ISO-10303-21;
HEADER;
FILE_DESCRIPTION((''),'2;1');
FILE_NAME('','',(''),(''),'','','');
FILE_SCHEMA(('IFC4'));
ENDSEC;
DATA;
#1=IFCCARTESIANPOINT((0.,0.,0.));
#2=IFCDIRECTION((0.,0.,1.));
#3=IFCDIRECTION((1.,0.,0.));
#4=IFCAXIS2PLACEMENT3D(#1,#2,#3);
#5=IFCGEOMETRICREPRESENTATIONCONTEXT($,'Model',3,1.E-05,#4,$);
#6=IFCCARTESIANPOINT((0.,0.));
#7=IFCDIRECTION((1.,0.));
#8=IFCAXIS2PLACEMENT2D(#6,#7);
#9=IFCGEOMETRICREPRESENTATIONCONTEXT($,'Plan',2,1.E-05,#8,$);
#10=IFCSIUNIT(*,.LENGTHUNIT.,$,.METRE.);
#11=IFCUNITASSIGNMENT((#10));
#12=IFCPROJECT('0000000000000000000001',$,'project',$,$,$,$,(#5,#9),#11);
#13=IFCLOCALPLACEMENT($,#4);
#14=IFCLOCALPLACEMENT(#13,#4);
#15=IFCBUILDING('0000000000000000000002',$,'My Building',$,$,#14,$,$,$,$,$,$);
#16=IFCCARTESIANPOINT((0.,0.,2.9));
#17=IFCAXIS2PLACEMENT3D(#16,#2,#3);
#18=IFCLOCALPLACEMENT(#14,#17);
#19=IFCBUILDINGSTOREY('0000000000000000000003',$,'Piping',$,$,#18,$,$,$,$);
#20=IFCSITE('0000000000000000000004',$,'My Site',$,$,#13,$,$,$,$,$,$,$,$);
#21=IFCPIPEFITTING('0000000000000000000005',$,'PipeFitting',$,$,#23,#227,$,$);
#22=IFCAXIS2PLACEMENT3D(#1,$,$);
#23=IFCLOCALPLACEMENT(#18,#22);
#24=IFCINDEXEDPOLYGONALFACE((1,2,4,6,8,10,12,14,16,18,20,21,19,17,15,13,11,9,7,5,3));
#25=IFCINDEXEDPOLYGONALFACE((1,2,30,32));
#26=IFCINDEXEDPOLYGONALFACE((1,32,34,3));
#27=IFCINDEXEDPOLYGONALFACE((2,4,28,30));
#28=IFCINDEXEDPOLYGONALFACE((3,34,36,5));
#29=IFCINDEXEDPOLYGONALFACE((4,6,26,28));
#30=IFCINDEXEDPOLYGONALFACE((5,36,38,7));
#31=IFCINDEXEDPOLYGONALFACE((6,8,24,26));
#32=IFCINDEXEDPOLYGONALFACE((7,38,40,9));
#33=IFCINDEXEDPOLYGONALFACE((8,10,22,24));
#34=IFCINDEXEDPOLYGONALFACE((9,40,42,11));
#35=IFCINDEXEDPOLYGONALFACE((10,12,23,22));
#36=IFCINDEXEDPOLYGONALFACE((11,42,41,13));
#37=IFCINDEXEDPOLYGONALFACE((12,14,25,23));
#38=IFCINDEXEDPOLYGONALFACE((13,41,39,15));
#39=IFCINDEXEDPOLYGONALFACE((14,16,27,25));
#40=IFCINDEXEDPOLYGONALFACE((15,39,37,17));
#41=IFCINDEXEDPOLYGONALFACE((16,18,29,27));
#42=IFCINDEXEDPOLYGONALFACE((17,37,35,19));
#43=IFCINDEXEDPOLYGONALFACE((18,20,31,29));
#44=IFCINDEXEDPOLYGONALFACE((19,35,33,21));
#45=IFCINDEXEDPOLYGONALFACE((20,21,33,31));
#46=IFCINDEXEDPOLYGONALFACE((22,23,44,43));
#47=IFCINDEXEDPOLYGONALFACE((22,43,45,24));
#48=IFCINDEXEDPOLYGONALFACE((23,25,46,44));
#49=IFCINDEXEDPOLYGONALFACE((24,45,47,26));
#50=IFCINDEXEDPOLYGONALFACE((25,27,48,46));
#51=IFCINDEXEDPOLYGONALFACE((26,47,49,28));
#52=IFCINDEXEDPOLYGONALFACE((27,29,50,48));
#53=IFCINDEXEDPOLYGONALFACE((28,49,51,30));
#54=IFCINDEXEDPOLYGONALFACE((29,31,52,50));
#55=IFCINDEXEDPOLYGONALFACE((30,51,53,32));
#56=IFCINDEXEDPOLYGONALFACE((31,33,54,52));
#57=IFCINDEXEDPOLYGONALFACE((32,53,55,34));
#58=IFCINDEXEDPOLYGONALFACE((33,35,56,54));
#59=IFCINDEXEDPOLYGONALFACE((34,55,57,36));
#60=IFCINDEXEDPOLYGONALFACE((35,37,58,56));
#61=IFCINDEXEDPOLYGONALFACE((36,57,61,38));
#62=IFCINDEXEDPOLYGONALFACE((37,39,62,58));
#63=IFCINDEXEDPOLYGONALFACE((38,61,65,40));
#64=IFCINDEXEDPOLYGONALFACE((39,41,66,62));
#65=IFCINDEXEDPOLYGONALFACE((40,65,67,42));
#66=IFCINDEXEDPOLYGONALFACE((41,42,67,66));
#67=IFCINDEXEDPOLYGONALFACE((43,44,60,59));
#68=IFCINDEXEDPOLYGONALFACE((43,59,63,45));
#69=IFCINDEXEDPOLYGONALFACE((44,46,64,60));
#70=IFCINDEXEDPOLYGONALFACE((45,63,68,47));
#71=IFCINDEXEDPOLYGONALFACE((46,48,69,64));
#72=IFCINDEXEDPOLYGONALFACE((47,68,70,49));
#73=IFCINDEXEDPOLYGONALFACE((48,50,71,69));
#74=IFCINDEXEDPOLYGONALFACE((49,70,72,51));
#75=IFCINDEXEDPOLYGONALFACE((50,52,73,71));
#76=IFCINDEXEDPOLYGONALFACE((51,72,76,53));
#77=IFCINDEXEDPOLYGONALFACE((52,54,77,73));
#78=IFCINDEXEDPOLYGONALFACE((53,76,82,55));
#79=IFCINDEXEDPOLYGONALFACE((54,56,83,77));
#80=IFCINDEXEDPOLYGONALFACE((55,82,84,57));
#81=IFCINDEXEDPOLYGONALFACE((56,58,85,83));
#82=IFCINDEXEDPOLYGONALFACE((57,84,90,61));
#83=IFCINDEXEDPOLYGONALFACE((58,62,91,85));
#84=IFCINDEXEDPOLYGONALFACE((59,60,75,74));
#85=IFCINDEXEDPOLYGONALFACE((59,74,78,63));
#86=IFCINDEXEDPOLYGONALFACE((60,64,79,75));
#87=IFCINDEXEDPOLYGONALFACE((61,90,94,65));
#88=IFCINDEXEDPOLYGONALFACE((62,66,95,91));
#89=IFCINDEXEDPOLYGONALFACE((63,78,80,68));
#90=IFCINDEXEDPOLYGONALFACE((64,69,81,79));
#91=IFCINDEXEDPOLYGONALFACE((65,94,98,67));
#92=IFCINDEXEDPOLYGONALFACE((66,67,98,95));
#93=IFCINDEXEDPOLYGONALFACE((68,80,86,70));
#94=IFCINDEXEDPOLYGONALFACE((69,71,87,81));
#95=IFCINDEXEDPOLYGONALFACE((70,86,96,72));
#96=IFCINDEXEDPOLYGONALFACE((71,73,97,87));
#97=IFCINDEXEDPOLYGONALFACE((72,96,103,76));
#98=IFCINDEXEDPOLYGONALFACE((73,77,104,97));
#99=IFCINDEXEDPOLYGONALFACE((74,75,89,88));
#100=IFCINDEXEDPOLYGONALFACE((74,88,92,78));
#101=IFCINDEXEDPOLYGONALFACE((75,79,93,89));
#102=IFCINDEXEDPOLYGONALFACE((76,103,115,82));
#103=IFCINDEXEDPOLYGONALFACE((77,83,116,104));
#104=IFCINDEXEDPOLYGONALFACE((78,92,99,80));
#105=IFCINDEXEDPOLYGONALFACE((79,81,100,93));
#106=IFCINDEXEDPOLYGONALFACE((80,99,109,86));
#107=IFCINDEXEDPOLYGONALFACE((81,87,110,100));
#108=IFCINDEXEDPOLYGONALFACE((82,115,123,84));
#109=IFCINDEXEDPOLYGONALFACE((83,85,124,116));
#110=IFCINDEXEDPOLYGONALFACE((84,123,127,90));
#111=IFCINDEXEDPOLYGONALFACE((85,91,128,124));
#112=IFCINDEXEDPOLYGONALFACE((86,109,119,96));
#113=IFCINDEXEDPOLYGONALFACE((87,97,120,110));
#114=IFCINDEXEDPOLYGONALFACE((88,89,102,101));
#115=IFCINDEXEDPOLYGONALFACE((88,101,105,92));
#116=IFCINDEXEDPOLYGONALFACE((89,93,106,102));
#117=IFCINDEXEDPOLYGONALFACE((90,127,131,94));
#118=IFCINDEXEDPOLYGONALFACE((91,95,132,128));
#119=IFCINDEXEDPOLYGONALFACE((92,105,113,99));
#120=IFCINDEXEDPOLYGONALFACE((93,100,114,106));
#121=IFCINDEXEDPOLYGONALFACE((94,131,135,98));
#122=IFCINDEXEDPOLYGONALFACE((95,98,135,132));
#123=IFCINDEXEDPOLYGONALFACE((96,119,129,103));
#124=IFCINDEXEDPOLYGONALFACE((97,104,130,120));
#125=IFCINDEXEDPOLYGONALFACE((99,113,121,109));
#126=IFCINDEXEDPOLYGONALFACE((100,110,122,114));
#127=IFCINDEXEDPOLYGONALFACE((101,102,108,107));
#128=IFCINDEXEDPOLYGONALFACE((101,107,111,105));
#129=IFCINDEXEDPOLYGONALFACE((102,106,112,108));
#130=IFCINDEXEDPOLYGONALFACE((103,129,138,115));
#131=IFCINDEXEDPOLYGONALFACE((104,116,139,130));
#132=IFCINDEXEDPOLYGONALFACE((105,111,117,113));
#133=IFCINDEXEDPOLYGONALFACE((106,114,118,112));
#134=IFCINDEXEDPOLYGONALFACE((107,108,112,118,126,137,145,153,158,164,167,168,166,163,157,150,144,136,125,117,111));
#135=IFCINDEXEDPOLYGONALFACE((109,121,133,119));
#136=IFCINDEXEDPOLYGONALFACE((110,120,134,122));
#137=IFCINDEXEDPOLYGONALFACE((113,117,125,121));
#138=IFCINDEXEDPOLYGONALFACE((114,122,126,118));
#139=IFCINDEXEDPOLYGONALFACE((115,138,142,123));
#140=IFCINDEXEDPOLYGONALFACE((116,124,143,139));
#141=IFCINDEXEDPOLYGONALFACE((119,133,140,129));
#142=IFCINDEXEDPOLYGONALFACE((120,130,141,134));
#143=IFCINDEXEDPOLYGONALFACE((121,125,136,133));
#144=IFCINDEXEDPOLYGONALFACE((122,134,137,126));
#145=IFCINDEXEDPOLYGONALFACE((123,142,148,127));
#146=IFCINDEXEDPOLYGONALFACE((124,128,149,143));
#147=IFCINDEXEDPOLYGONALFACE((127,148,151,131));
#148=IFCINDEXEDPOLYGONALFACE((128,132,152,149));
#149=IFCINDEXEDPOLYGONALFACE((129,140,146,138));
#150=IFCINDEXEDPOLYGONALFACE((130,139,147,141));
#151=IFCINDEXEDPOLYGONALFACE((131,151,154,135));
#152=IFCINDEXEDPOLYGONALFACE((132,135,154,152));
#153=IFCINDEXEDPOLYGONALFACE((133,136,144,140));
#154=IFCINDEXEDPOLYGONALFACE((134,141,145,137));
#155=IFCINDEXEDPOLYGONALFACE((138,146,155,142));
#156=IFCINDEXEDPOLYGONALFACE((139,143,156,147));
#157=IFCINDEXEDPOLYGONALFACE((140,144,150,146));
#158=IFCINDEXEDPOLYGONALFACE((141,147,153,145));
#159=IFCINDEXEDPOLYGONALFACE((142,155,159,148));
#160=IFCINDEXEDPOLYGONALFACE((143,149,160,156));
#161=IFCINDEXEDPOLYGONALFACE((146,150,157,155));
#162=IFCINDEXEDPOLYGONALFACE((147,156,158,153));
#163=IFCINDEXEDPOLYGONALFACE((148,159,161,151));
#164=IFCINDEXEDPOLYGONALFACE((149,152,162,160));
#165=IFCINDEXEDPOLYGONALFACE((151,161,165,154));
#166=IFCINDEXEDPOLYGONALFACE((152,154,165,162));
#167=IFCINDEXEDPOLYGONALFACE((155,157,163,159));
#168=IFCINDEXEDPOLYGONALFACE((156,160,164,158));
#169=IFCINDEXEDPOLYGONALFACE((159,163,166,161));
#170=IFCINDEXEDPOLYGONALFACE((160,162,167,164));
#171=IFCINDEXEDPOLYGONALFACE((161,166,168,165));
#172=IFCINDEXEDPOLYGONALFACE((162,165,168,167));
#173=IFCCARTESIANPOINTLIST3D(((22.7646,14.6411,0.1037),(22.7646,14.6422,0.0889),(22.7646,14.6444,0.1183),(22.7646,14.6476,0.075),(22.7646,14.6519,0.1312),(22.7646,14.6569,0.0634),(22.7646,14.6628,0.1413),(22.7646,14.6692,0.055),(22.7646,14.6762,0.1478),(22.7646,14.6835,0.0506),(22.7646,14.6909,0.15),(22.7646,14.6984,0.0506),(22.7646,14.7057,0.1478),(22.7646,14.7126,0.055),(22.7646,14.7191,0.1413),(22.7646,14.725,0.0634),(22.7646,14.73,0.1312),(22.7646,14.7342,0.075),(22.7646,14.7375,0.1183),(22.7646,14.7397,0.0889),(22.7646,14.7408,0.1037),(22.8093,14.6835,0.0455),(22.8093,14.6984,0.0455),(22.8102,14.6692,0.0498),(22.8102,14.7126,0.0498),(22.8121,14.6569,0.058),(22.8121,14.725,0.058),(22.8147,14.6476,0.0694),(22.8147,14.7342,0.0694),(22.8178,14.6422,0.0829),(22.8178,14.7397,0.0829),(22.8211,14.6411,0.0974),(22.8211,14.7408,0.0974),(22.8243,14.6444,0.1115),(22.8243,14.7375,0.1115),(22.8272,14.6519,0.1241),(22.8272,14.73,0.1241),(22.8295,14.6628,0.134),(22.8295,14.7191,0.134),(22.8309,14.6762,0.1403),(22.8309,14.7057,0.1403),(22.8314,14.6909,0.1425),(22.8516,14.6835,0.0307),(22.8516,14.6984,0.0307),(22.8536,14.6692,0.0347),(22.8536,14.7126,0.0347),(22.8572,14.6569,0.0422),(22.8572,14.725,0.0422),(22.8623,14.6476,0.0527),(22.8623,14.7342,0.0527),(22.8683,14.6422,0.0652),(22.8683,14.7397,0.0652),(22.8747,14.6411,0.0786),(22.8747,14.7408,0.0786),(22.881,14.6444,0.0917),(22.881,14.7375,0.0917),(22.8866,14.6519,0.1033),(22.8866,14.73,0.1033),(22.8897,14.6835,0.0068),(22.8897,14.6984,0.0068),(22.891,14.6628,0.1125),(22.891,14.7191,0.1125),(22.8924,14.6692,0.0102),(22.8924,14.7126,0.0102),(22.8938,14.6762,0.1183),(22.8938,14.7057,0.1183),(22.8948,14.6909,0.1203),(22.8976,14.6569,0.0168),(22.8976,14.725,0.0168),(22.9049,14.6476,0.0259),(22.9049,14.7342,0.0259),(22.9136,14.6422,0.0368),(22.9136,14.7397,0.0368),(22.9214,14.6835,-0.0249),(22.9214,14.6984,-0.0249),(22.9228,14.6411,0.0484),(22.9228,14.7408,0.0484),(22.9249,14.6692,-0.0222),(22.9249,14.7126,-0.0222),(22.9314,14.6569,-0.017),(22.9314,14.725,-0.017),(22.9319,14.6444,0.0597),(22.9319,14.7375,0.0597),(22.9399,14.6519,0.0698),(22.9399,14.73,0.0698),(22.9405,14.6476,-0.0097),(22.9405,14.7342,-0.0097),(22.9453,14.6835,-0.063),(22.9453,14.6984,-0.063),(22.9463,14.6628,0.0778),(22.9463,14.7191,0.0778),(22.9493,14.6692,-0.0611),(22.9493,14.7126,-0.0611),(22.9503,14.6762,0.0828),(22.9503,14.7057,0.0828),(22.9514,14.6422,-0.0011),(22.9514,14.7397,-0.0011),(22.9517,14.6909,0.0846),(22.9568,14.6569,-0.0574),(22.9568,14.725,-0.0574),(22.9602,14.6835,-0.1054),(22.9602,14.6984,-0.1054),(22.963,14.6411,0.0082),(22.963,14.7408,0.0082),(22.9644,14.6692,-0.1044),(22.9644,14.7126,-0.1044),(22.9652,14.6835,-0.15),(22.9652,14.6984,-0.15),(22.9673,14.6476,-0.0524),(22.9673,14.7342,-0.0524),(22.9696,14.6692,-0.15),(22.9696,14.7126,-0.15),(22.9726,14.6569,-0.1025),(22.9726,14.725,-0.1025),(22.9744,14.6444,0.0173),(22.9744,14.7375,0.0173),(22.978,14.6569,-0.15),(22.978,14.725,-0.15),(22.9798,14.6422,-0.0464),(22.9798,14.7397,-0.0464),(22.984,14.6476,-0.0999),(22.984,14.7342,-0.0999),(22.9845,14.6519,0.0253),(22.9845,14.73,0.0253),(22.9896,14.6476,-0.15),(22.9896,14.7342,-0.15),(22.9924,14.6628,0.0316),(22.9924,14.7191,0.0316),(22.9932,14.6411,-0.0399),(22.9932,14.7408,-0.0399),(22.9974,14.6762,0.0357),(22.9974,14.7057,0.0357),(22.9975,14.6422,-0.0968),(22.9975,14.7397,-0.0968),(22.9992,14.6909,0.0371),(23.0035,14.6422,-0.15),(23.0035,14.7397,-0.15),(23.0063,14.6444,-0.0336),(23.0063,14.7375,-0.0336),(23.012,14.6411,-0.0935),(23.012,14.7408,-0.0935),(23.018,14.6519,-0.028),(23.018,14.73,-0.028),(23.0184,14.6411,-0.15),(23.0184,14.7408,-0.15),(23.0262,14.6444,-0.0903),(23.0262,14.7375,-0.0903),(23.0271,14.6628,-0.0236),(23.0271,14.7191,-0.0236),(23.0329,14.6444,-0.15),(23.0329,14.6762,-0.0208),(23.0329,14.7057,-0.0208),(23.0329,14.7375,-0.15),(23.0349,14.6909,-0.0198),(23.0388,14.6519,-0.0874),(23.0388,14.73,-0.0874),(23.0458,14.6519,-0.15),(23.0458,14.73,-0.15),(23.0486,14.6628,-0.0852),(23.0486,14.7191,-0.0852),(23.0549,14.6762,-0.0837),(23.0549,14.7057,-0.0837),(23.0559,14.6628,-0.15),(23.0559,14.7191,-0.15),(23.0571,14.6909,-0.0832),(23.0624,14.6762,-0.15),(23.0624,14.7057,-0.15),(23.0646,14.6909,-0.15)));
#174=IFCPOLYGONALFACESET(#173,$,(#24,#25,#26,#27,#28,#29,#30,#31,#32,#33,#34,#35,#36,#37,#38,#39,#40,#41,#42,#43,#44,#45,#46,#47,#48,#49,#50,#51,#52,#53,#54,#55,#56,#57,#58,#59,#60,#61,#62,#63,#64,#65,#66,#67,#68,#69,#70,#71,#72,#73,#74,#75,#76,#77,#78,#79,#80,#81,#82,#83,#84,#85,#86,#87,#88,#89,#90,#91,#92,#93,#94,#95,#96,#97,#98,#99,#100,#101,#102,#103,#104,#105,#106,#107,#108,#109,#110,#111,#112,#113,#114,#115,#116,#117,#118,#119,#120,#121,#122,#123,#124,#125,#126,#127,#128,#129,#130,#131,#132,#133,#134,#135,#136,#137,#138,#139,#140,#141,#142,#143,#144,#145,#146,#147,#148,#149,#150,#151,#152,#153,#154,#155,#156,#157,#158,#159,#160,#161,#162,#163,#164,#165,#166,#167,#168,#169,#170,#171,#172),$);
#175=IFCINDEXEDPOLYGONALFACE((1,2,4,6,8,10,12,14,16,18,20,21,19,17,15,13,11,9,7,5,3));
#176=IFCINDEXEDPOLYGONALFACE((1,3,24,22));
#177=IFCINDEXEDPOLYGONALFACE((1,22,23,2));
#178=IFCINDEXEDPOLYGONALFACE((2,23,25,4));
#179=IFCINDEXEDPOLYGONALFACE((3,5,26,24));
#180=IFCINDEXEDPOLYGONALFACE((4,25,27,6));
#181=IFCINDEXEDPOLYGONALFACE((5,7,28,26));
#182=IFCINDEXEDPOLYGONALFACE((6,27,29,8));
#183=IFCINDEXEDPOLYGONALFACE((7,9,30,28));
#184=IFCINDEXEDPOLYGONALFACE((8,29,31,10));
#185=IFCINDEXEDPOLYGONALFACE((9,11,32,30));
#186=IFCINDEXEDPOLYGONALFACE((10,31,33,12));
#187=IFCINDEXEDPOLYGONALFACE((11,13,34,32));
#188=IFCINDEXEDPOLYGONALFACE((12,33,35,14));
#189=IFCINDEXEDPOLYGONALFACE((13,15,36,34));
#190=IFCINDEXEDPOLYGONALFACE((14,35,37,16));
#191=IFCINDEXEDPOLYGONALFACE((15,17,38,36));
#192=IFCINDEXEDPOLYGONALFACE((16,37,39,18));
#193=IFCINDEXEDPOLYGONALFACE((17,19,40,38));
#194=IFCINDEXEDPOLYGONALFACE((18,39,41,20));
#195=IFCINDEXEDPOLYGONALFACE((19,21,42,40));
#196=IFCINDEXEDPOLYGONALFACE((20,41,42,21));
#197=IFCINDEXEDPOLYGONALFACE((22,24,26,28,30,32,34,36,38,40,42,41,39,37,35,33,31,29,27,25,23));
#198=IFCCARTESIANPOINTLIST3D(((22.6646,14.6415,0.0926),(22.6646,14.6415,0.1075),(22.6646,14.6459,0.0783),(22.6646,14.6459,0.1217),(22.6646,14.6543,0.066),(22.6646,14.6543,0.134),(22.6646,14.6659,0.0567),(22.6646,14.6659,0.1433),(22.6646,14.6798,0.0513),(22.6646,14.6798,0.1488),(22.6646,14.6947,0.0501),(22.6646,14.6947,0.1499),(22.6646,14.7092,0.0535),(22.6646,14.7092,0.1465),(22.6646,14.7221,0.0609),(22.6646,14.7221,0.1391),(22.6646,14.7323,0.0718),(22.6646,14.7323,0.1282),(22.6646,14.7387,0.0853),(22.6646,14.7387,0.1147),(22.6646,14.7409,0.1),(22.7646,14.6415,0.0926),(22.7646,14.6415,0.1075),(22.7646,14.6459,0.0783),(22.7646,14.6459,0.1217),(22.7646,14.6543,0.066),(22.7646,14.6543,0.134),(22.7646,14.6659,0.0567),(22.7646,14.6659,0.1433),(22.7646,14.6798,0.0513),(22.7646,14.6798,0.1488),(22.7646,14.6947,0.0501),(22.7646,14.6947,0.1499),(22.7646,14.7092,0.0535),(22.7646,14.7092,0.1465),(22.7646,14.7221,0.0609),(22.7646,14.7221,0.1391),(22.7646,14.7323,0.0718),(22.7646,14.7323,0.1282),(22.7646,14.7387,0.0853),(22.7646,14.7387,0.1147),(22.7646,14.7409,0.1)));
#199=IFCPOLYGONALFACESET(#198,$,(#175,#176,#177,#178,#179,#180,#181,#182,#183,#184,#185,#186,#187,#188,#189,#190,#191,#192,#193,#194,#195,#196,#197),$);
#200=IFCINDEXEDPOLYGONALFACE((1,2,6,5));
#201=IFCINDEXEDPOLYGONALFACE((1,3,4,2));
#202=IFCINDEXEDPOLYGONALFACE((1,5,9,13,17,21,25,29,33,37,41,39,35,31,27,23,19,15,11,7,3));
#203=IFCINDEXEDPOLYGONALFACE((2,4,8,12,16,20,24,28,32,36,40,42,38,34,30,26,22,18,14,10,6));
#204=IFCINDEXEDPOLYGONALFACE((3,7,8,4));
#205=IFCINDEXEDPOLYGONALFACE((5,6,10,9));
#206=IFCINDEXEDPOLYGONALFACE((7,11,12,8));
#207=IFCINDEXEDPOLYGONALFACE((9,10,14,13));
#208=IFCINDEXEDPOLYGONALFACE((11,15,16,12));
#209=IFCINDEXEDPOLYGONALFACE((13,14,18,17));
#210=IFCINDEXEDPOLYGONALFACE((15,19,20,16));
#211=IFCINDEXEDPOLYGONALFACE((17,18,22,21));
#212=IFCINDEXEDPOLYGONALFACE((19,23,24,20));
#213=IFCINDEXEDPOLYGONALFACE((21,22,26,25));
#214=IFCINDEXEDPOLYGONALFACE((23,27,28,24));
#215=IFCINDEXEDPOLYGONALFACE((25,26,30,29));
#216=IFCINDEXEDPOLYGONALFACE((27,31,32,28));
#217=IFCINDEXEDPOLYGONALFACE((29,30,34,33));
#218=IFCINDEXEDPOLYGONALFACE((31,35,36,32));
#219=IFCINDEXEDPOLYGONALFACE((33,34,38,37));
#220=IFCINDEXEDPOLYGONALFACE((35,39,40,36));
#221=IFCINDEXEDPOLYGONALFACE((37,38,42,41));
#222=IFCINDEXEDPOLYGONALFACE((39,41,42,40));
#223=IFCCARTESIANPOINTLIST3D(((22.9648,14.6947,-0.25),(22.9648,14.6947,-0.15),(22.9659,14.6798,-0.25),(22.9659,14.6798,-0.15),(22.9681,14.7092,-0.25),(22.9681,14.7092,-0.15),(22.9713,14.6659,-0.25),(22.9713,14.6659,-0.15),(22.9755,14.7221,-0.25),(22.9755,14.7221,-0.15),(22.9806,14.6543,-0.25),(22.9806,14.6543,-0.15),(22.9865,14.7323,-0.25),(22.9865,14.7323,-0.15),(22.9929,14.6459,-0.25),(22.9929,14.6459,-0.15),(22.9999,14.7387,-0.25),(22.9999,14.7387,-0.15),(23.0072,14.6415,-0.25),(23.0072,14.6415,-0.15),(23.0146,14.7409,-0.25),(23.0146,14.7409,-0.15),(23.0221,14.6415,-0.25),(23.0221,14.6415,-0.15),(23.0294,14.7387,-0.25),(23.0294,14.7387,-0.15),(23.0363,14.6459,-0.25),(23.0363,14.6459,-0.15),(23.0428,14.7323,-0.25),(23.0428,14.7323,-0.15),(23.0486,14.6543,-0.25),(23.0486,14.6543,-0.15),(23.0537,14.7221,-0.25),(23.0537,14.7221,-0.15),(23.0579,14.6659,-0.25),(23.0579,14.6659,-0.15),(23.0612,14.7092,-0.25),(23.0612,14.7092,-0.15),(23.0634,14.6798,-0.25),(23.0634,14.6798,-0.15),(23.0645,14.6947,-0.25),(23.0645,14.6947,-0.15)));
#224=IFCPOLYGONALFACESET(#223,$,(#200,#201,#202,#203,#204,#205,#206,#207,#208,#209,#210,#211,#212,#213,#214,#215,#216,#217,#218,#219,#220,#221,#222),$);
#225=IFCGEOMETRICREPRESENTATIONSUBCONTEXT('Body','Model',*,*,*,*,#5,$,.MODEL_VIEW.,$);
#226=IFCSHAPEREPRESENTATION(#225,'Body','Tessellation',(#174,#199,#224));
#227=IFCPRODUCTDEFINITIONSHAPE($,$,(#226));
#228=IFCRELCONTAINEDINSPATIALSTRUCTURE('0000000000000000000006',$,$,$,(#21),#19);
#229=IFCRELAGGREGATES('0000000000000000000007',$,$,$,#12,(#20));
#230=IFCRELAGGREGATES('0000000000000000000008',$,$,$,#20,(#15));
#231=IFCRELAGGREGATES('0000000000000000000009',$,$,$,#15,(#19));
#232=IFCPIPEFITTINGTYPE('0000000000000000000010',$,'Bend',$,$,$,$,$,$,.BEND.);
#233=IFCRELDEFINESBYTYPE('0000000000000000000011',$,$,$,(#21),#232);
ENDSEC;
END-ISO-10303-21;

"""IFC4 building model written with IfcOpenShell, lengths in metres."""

from ifc_helpers import new_model, entity, si_unit, frame, origin_with_axes, origin_2d_with_axis, place, context, subcontext, project, spatial, circle, extrude, source, transform, mapped, type_object, type_shapes, element, save


model = new_model("IFC4")

# Units and contexts
model_context = context("Model", 3, precision=1e-05, world=origin_with_axes())
plan_context = context("Plan", 2, precision=1e-05, world=origin_2d_with_axis())
body_context = subcontext(model_context, "Body", "Model", "MODEL_VIEW")
ifc_project = project(units=[si_unit("LENGTHUNIT", "METRE")], contexts=[model_context, plan_context])

# Site, building, storey
site_placement = place(None, origin_with_axes())
site = spatial("IfcSite", under=ifc_project, at=site_placement, Name="My Site")
building_placement = place(site_placement, origin_with_axes())
building = spatial("IfcBuilding", under=site, at=building_placement, Name="My Building")
storey_placement = place(building_placement, frame((0.0, 0.0, 2.9), z_axis=(0.0, 0.0, 1.0), x_axis=(1.0, 0.0, 0.0)))
storey = spatial("IfcBuildingStorey", under=building, at=storey_placement, Name="Piping")

# Pipe fitting
pipe_fitting_type = type_object("IfcPipeFittingType", Name="Bend", PredefinedType="BEND")
shared_shape = source(origin_with_axes(), body_context, "Body", "SolidModel", [
    entity("IfcSweptDiskSolid", entity("IfcIndexedPolyCurve", entity("IfcCartesianPointList3D", [[0.0, 0.0, 0.1], [0.0, -0.0732, 0.2768], [0.0, -0.25, 0.35]]), [entity("IfcArcIndex", [1, 2, 3])]), 0.05),
    extrude(circle(Radius=0.05), origin_with_axes(), (0.0, 0.0, 1.0), 0.1),
    extrude(circle(Radius=0.05), frame((0.0, -0.25, 0.35), z_axis=(0.0, -1.0, -0.000001), x_axis=(1.0, 0.0, 0.0)), (0.0, 0.0, 1.0), 0.1),
])
type_shapes(pipe_fitting_type, [shared_shape])
for number, where, z_axis, x_axis, name in (
    (1, (22.6646, 14.6909, 0.1), (1.0, -0.000001, 0.000001), (0.000001, 1.0, 0.0), "PipeFitting"),
):
    element("IfcPipeFitting", number, at=place(storey_placement, frame(where, z_axis=z_axis, x_axis=x_axis)), inside=storey, type_object=pipe_fitting_type, Name=name, context=body_context, shape_type="MappedRepresentation", body=[
        mapped(shared_shape, transform((0.0, 0.0, 0.0), x_axis=(1.0, 0.0, 0.0), y_axis=(0.0, 1.0, 0.0), z_axis=(0.0, 0.0, 1.0), scale=1.0)),
    ])

save(model, "model.ifc")
